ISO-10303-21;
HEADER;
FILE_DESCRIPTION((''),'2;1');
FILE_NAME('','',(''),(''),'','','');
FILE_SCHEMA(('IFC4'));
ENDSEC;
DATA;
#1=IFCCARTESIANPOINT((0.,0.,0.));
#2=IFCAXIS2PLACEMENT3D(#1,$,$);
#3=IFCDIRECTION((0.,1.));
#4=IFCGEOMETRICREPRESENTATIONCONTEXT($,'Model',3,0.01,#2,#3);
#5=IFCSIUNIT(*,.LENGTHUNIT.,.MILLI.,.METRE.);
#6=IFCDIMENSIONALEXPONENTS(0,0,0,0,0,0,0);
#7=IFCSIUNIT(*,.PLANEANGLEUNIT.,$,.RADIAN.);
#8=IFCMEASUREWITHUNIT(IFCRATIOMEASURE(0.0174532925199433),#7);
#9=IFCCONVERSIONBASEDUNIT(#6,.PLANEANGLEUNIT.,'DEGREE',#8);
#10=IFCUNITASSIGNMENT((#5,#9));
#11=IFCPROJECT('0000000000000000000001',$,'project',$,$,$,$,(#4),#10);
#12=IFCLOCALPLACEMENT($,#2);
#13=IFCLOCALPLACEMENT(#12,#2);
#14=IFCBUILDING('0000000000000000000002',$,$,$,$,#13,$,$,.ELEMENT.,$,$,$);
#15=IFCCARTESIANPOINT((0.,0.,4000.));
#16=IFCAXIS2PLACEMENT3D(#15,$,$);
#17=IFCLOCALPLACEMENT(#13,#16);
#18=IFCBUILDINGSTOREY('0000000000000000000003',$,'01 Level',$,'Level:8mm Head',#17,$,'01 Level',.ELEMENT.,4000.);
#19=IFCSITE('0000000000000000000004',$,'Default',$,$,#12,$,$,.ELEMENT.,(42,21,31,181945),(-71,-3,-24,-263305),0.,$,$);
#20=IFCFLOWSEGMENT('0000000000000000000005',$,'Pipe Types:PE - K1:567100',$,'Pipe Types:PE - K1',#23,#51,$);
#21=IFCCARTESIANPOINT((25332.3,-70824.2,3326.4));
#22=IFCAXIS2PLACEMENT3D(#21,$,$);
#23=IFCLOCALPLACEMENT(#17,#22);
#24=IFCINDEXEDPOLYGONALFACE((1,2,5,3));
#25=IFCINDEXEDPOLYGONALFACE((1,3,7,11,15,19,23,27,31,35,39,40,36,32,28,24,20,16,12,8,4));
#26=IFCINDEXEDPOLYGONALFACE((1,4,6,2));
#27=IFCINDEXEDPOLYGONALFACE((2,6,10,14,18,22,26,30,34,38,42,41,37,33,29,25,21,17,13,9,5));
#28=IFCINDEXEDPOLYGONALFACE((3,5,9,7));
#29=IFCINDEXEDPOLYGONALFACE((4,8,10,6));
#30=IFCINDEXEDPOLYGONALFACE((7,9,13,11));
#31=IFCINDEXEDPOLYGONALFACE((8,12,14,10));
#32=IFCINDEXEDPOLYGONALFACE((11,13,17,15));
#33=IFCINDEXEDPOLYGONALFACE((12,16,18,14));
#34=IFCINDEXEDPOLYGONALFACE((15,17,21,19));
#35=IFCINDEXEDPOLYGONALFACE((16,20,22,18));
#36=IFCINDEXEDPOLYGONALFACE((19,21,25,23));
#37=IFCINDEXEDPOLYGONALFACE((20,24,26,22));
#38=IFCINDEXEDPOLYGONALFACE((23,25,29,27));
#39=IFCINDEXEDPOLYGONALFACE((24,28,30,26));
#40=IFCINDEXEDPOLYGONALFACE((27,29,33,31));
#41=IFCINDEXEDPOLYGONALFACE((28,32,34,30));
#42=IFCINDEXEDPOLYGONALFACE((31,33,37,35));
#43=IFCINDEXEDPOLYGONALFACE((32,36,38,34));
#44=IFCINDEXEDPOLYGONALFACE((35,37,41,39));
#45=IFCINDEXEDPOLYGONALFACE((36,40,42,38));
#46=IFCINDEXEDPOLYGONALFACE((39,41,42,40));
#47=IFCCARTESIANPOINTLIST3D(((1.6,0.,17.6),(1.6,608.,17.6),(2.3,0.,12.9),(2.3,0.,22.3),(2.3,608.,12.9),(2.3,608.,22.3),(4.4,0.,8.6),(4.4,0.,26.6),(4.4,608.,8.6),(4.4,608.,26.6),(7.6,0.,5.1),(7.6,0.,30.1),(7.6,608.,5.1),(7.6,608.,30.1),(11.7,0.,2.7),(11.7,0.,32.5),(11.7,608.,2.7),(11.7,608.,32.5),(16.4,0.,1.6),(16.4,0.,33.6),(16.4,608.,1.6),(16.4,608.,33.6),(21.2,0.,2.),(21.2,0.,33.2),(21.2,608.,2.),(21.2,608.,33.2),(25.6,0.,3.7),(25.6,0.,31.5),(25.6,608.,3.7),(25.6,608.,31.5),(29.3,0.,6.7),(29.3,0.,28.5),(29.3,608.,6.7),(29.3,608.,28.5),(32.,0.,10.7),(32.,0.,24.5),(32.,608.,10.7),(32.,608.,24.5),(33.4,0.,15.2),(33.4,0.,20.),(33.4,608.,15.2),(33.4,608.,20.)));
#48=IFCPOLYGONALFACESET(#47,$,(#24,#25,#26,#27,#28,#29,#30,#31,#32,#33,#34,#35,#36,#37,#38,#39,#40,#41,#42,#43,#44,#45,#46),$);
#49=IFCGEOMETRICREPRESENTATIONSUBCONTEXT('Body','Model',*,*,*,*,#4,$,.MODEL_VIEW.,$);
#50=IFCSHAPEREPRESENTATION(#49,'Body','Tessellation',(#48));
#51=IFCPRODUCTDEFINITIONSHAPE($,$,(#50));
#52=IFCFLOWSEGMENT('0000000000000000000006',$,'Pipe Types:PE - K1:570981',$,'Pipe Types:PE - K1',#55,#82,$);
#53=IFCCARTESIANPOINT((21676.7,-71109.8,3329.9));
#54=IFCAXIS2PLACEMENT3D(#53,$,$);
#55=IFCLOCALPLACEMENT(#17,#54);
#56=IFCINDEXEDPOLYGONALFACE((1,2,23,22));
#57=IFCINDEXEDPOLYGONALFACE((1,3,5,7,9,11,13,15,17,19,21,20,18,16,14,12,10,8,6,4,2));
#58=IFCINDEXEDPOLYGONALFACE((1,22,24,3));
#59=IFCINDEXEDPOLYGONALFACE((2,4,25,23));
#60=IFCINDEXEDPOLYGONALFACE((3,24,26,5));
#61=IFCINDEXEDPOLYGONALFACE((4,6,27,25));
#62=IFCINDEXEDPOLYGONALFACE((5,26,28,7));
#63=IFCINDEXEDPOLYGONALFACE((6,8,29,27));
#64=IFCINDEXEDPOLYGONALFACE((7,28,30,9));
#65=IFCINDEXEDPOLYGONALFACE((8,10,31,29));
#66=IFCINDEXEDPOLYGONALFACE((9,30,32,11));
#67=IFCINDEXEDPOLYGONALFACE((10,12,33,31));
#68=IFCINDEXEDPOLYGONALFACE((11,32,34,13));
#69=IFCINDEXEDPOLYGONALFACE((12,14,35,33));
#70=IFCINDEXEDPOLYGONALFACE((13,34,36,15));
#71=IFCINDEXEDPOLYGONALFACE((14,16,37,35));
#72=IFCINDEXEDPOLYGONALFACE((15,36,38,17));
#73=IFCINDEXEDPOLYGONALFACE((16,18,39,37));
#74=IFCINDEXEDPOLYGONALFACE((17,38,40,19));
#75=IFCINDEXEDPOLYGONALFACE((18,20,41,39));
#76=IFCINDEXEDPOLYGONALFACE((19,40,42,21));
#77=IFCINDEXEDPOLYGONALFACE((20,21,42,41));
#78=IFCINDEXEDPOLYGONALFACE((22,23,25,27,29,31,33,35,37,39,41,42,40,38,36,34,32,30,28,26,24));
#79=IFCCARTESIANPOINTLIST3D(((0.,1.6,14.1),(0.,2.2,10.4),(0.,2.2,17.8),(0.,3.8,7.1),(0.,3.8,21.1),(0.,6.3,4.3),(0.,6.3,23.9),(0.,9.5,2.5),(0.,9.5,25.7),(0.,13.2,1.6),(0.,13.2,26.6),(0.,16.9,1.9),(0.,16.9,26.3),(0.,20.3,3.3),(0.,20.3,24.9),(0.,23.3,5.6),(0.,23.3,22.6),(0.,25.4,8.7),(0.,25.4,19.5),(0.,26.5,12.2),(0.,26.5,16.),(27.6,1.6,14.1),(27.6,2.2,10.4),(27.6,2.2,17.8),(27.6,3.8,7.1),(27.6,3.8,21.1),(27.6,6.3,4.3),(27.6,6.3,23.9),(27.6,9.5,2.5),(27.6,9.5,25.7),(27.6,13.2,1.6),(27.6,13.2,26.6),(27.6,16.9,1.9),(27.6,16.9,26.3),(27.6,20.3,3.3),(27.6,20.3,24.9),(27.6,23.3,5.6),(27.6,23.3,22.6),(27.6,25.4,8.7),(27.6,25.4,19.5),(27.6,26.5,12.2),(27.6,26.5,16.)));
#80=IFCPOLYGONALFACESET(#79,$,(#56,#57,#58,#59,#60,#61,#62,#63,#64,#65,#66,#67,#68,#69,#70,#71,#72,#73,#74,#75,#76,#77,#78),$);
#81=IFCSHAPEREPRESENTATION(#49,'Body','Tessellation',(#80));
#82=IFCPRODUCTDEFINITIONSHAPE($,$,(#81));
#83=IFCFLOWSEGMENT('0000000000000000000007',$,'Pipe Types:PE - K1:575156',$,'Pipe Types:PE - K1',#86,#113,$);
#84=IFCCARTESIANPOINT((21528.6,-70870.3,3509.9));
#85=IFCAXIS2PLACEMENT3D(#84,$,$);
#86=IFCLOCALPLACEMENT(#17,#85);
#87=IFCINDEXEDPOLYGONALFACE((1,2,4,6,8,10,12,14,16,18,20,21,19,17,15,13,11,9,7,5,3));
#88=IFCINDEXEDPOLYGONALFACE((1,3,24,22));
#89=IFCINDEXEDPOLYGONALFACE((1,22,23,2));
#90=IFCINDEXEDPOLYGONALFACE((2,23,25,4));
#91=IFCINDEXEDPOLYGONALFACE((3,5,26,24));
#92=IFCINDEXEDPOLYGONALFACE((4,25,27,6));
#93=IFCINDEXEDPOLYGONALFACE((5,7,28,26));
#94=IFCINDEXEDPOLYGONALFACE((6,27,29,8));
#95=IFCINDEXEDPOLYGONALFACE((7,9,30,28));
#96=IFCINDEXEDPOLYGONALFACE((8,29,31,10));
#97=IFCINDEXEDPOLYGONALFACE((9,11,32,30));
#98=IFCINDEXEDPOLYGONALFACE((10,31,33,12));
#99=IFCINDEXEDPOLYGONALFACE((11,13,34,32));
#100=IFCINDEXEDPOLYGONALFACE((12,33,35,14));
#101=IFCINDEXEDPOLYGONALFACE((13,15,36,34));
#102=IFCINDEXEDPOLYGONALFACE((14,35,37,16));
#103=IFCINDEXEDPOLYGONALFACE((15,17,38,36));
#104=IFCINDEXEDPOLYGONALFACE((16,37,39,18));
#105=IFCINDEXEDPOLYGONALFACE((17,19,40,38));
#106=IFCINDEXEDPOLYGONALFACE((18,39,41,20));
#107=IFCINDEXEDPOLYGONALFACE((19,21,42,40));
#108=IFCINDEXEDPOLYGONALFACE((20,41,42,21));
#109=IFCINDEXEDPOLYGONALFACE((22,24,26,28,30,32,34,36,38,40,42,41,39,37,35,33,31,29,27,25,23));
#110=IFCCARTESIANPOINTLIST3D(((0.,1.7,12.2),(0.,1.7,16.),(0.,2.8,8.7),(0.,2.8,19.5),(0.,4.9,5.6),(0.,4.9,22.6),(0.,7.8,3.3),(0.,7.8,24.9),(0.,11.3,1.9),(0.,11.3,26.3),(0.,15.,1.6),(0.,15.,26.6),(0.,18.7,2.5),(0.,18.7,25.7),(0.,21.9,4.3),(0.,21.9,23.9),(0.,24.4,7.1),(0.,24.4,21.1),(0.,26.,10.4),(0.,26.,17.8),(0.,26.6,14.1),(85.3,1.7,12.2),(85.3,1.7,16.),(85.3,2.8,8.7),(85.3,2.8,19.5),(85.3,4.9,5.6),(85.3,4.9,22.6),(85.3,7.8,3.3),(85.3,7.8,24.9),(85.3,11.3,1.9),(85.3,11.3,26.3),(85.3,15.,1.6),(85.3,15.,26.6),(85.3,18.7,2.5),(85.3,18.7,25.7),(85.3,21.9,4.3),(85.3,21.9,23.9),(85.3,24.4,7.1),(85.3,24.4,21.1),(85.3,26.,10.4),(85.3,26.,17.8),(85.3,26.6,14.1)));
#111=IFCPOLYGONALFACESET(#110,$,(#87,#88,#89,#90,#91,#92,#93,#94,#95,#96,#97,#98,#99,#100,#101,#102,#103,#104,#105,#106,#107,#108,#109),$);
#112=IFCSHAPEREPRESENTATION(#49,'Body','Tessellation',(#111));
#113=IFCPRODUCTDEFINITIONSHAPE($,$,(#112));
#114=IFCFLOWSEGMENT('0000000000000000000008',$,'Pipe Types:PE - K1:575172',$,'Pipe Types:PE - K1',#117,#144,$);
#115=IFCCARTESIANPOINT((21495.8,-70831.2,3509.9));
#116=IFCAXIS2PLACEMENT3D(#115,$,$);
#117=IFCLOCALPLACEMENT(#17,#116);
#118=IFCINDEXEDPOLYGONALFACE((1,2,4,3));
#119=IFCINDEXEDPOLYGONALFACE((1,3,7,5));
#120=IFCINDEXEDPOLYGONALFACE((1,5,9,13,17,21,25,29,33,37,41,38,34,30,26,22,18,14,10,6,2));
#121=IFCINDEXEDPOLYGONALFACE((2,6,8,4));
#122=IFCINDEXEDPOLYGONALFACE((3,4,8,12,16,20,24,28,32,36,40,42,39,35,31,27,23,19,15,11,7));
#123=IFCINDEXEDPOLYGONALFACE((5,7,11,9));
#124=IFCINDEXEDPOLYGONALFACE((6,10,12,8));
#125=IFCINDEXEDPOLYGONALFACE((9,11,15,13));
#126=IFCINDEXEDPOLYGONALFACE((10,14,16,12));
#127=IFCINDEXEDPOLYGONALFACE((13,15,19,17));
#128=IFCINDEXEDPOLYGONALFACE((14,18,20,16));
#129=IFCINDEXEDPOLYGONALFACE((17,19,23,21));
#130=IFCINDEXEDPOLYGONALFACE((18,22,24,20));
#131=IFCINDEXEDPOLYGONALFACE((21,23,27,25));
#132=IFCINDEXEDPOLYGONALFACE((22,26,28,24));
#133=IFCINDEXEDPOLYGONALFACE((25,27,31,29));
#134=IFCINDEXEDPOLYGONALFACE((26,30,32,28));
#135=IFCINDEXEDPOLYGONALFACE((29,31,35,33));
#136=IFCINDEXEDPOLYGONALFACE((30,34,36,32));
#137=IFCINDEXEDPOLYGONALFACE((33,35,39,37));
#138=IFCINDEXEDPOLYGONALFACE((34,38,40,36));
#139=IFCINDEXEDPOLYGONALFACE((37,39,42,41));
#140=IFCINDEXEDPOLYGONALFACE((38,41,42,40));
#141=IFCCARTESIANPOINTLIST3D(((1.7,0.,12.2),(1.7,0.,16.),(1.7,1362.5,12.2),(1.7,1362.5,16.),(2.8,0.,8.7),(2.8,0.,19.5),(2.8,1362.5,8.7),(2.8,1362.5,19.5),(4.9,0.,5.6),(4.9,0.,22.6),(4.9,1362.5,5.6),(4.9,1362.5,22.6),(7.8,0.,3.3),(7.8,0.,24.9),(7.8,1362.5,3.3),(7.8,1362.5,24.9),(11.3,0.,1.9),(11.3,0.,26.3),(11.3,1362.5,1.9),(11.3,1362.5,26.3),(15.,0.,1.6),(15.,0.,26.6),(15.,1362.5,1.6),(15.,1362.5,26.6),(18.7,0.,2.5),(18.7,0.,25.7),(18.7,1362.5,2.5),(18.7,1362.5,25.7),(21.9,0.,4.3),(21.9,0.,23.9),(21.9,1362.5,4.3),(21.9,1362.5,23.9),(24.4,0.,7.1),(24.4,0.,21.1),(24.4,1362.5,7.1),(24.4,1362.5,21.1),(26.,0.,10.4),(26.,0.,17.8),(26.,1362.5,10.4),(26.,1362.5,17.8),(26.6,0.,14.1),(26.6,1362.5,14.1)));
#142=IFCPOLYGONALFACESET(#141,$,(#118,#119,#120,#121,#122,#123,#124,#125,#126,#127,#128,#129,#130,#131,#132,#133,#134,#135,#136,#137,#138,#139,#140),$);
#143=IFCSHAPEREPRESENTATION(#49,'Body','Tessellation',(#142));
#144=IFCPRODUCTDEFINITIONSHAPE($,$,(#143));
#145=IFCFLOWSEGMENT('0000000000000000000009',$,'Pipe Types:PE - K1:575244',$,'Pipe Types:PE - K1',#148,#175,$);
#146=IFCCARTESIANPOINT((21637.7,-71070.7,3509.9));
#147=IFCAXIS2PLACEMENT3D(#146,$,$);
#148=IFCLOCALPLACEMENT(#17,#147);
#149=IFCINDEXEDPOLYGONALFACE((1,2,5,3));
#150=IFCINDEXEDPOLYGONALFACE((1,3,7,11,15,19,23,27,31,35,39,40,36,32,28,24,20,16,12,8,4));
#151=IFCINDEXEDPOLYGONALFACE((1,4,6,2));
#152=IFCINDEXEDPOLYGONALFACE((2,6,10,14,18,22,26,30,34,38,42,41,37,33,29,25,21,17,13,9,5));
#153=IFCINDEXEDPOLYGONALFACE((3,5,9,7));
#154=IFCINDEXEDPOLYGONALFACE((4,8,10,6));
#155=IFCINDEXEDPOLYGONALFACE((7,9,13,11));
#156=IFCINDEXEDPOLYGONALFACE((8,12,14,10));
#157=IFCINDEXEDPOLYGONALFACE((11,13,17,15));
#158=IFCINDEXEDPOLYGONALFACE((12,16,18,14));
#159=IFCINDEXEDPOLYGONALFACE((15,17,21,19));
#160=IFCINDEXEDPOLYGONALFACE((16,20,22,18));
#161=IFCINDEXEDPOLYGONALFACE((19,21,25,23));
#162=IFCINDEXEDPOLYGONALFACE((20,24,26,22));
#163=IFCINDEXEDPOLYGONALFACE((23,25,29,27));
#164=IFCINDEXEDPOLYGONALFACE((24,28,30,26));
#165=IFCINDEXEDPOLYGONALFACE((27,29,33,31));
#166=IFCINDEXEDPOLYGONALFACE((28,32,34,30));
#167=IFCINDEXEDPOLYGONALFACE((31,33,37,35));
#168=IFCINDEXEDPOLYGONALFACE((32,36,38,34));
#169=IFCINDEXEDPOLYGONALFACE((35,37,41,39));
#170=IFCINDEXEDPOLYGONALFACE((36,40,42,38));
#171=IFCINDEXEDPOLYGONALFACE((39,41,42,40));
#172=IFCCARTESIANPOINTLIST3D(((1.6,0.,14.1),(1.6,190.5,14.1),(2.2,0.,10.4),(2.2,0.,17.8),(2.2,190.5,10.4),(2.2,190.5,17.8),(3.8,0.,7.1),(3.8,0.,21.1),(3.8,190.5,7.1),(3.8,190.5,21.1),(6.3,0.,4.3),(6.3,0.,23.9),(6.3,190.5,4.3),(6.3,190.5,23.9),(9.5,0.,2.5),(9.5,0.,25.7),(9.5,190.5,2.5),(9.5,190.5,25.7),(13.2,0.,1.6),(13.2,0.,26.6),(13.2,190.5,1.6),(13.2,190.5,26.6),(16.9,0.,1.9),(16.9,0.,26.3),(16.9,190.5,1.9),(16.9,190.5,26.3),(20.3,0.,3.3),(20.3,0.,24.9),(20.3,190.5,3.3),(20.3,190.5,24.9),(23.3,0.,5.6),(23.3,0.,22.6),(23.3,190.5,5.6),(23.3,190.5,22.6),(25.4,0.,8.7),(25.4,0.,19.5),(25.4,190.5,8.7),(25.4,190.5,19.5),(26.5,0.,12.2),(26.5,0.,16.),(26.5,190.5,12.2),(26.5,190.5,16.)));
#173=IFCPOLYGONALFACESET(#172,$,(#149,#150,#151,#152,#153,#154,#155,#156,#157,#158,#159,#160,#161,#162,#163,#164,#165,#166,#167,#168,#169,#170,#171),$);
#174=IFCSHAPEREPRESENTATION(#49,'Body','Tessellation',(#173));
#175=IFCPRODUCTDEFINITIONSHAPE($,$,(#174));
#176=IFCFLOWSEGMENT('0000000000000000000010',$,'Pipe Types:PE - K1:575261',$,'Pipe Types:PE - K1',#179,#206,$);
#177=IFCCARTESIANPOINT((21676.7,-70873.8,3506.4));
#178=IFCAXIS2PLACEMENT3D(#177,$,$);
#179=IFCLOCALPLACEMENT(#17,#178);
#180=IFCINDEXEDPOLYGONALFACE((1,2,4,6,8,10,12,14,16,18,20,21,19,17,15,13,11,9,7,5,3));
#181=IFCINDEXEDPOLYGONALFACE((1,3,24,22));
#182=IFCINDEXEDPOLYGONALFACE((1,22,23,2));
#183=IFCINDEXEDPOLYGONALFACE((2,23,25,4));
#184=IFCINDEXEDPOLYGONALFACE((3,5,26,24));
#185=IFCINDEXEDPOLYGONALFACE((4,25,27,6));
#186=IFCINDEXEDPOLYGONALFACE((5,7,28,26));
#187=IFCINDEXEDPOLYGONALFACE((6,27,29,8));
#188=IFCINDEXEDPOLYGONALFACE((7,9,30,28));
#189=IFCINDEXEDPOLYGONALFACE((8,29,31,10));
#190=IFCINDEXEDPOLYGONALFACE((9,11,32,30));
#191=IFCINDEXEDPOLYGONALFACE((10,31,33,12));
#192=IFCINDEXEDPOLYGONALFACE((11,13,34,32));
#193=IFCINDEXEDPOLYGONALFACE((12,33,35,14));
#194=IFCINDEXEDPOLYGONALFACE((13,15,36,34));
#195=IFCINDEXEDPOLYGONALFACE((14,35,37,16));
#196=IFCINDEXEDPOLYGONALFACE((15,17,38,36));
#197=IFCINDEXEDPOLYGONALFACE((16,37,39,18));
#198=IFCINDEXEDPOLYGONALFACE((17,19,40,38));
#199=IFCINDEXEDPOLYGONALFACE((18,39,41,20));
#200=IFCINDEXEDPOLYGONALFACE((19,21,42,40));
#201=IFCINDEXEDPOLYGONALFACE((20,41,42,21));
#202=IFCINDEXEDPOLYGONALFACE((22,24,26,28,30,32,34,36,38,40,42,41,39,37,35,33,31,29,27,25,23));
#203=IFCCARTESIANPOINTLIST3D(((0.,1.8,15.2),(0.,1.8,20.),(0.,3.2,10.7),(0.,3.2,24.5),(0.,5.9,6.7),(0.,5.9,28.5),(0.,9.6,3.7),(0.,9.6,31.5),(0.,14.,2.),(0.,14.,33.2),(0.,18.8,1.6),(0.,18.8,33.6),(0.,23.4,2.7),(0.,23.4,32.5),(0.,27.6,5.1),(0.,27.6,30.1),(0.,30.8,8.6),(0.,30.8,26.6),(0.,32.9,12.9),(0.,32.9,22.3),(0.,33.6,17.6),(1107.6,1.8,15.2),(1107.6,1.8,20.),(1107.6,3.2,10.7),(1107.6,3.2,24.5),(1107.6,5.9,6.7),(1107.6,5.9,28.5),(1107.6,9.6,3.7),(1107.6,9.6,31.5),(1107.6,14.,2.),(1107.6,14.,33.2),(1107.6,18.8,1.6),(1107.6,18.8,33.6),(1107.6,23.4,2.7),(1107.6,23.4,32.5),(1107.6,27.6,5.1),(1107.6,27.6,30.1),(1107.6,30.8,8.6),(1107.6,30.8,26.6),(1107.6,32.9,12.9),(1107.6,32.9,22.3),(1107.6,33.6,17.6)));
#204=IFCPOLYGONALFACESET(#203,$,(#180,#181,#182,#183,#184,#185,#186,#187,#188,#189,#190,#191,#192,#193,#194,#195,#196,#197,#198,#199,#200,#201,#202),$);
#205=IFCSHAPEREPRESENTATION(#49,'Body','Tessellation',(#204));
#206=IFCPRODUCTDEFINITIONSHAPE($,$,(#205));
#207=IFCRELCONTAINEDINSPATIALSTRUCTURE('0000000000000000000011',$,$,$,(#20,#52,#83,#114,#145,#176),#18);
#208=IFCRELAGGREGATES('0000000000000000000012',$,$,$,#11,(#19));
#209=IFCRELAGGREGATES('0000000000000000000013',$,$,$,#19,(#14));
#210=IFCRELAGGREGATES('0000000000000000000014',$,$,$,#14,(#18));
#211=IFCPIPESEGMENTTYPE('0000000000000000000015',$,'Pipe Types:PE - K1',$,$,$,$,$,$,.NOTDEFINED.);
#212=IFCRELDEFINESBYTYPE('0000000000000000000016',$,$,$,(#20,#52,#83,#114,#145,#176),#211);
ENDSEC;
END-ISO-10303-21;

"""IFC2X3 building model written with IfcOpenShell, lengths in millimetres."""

from ifc_helpers import new_model, entity, si_unit, converted_unit, direction, frame, frame_2d, origin, origin_2d_with_axis, place, context, subcontext, project, spatial, circle, extrude, type_object, element, save


model = new_model("IFC2X3")

# Units and contexts
model_context = context("Model", 3, precision=0.01, world=origin(), true_north=direction((0.0, 1.0)))
body_context = subcontext(model_context, "Body", "Model", "MODEL_VIEW")
ifc_project = project(units=[si_unit("LENGTHUNIT", "METRE", prefix="MILLI"), converted_unit("PLANEANGLEUNIT", "DEGREE", entity("IfcRatioMeasure", 0.0174532925199433), si_unit("PLANEANGLEUNIT", "RADIAN"), dimensions=[0, 0, 0, 0, 0, 0, 0])], contexts=[model_context])

# Site, building, storey
site_placement = place(None, origin())
site = spatial("IfcSite", under=ifc_project, at=site_placement, Name="Default", CompositionType="ELEMENT", RefLatitude=(42, 21, 31, 181945), RefLongitude=(-71, -3, -24, -263305), RefElevation=0.0)
building_placement = place(site_placement, origin())
building = spatial("IfcBuilding", under=site, at=building_placement, CompositionType="ELEMENT")
storey_placement = place(building_placement, frame((0.0, 0.0, 4000.0)))
storey = spatial("IfcBuildingStorey", under=building, at=storey_placement, Name="01 Level", ObjectType="Level:8mm Head", LongName="01 Level", CompositionType="ELEMENT", Elevation=4000.0)

# Flow segments
pipe_segment_type = type_object("IfcPipeSegmentType", Name="Pipe Types:PE - K1", PredefinedType="NOTDEFINED")
flow_segment_1_placement = place(storey_placement, frame((25332.3, -70824.2, 3326.4)))
element("IfcFlowSegment", 1, at=flow_segment_1_placement, inside=storey, type_object=pipe_segment_type, Name="Pipe Types:PE - K1:567100", ObjectType="Pipe Types:PE - K1", context=body_context, shape_type="SweptSolid", body=[
    extrude(circle(Radius=16.0, at=frame_2d((0.0, 0.0), x_axis=(1.0, 0.0))), frame((17.6, 0.0, 17.6), z_axis=(0.0, 1.0, 0.0), x_axis=(-1.0, 0.0, 0.0)), (0.0, 0.0, 1.0), 608.0),
])
flow_segment_2_placement = place(storey_placement, frame((21676.7, -71109.8, 3329.9)))
element("IfcFlowSegment", 2, at=flow_segment_2_placement, inside=storey, type_object=pipe_segment_type, Name="Pipe Types:PE - K1:570981", ObjectType="Pipe Types:PE - K1", context=body_context, shape_type="SweptSolid", body=[
    extrude(circle(Radius=12.5, at=origin_2d_with_axis()), frame((0.0, 14.1, 14.1), z_axis=(1.0, 0.0, 0.0), x_axis=(0.0, -1.0, 0.0)), (0.0, 0.0, 1.0), 27.6),
])
flow_segment_3_placement = place(storey_placement, frame((21528.6, -70870.3, 3509.9)))
element("IfcFlowSegment", 3, at=flow_segment_3_placement, inside=storey, type_object=pipe_segment_type, Name="Pipe Types:PE - K1:575156", ObjectType="Pipe Types:PE - K1", context=body_context, shape_type="SweptSolid", body=[
    extrude(circle(Radius=12.5, at=frame_2d((0.0, 0.0), x_axis=(1.0, 0.0))), frame((0.0, 14.1, 14.1), z_axis=(1.0, 0.0, 0.0), x_axis=(0.0, 1.0, 0.0)), (0.0, 0.0, 1.0), 85.3),
])
flow_segment_4_placement = place(storey_placement, frame((21495.8, -70831.2, 3509.9)))
element("IfcFlowSegment", 4, at=flow_segment_4_placement, inside=storey, type_object=pipe_segment_type, Name="Pipe Types:PE - K1:575172", ObjectType="Pipe Types:PE - K1", context=body_context, shape_type="SweptSolid", body=[
    extrude(circle(Radius=12.5, at=origin_2d_with_axis()), frame((14.1, 0.0, 14.1), z_axis=(0.0, 1.0, 0.0), x_axis=(1.0, 0.0, 0.0)), (0.0, 0.0, 1.0), 1362.5),
])
flow_segment_5_placement = place(storey_placement, frame((21637.7, -71070.7, 3509.9)))
element("IfcFlowSegment", 5, at=flow_segment_5_placement, inside=storey, type_object=pipe_segment_type, Name="Pipe Types:PE - K1:575244", ObjectType="Pipe Types:PE - K1", context=body_context, shape_type="SweptSolid", body=[
    extrude(circle(Radius=12.5, at=frame_2d((0.0, 0.0), x_axis=(1.0, 0.0))), frame((14.1, 0.0, 14.1), z_axis=(0.0, 1.0, 0.0), x_axis=(-1.0, 0.0, 0.0)), (0.0, 0.0, 1.0), 190.5),
])
flow_segment_6_placement = place(storey_placement, frame((21676.7, -70873.8, 3506.4)))
element("IfcFlowSegment", 6, at=flow_segment_6_placement, inside=storey, type_object=pipe_segment_type, Name="Pipe Types:PE - K1:575261", ObjectType="Pipe Types:PE - K1", context=body_context, shape_type="SweptSolid", body=[
    extrude(circle(Radius=16.0, at=origin_2d_with_axis()), frame((0.0, 17.6, 17.6), z_axis=(1.0, 0.0, 0.0), x_axis=(0.0, 1.0, 0.0)), (0.0, 0.0, 1.0), 1107.6),
])

save(model, "model.ifc")
